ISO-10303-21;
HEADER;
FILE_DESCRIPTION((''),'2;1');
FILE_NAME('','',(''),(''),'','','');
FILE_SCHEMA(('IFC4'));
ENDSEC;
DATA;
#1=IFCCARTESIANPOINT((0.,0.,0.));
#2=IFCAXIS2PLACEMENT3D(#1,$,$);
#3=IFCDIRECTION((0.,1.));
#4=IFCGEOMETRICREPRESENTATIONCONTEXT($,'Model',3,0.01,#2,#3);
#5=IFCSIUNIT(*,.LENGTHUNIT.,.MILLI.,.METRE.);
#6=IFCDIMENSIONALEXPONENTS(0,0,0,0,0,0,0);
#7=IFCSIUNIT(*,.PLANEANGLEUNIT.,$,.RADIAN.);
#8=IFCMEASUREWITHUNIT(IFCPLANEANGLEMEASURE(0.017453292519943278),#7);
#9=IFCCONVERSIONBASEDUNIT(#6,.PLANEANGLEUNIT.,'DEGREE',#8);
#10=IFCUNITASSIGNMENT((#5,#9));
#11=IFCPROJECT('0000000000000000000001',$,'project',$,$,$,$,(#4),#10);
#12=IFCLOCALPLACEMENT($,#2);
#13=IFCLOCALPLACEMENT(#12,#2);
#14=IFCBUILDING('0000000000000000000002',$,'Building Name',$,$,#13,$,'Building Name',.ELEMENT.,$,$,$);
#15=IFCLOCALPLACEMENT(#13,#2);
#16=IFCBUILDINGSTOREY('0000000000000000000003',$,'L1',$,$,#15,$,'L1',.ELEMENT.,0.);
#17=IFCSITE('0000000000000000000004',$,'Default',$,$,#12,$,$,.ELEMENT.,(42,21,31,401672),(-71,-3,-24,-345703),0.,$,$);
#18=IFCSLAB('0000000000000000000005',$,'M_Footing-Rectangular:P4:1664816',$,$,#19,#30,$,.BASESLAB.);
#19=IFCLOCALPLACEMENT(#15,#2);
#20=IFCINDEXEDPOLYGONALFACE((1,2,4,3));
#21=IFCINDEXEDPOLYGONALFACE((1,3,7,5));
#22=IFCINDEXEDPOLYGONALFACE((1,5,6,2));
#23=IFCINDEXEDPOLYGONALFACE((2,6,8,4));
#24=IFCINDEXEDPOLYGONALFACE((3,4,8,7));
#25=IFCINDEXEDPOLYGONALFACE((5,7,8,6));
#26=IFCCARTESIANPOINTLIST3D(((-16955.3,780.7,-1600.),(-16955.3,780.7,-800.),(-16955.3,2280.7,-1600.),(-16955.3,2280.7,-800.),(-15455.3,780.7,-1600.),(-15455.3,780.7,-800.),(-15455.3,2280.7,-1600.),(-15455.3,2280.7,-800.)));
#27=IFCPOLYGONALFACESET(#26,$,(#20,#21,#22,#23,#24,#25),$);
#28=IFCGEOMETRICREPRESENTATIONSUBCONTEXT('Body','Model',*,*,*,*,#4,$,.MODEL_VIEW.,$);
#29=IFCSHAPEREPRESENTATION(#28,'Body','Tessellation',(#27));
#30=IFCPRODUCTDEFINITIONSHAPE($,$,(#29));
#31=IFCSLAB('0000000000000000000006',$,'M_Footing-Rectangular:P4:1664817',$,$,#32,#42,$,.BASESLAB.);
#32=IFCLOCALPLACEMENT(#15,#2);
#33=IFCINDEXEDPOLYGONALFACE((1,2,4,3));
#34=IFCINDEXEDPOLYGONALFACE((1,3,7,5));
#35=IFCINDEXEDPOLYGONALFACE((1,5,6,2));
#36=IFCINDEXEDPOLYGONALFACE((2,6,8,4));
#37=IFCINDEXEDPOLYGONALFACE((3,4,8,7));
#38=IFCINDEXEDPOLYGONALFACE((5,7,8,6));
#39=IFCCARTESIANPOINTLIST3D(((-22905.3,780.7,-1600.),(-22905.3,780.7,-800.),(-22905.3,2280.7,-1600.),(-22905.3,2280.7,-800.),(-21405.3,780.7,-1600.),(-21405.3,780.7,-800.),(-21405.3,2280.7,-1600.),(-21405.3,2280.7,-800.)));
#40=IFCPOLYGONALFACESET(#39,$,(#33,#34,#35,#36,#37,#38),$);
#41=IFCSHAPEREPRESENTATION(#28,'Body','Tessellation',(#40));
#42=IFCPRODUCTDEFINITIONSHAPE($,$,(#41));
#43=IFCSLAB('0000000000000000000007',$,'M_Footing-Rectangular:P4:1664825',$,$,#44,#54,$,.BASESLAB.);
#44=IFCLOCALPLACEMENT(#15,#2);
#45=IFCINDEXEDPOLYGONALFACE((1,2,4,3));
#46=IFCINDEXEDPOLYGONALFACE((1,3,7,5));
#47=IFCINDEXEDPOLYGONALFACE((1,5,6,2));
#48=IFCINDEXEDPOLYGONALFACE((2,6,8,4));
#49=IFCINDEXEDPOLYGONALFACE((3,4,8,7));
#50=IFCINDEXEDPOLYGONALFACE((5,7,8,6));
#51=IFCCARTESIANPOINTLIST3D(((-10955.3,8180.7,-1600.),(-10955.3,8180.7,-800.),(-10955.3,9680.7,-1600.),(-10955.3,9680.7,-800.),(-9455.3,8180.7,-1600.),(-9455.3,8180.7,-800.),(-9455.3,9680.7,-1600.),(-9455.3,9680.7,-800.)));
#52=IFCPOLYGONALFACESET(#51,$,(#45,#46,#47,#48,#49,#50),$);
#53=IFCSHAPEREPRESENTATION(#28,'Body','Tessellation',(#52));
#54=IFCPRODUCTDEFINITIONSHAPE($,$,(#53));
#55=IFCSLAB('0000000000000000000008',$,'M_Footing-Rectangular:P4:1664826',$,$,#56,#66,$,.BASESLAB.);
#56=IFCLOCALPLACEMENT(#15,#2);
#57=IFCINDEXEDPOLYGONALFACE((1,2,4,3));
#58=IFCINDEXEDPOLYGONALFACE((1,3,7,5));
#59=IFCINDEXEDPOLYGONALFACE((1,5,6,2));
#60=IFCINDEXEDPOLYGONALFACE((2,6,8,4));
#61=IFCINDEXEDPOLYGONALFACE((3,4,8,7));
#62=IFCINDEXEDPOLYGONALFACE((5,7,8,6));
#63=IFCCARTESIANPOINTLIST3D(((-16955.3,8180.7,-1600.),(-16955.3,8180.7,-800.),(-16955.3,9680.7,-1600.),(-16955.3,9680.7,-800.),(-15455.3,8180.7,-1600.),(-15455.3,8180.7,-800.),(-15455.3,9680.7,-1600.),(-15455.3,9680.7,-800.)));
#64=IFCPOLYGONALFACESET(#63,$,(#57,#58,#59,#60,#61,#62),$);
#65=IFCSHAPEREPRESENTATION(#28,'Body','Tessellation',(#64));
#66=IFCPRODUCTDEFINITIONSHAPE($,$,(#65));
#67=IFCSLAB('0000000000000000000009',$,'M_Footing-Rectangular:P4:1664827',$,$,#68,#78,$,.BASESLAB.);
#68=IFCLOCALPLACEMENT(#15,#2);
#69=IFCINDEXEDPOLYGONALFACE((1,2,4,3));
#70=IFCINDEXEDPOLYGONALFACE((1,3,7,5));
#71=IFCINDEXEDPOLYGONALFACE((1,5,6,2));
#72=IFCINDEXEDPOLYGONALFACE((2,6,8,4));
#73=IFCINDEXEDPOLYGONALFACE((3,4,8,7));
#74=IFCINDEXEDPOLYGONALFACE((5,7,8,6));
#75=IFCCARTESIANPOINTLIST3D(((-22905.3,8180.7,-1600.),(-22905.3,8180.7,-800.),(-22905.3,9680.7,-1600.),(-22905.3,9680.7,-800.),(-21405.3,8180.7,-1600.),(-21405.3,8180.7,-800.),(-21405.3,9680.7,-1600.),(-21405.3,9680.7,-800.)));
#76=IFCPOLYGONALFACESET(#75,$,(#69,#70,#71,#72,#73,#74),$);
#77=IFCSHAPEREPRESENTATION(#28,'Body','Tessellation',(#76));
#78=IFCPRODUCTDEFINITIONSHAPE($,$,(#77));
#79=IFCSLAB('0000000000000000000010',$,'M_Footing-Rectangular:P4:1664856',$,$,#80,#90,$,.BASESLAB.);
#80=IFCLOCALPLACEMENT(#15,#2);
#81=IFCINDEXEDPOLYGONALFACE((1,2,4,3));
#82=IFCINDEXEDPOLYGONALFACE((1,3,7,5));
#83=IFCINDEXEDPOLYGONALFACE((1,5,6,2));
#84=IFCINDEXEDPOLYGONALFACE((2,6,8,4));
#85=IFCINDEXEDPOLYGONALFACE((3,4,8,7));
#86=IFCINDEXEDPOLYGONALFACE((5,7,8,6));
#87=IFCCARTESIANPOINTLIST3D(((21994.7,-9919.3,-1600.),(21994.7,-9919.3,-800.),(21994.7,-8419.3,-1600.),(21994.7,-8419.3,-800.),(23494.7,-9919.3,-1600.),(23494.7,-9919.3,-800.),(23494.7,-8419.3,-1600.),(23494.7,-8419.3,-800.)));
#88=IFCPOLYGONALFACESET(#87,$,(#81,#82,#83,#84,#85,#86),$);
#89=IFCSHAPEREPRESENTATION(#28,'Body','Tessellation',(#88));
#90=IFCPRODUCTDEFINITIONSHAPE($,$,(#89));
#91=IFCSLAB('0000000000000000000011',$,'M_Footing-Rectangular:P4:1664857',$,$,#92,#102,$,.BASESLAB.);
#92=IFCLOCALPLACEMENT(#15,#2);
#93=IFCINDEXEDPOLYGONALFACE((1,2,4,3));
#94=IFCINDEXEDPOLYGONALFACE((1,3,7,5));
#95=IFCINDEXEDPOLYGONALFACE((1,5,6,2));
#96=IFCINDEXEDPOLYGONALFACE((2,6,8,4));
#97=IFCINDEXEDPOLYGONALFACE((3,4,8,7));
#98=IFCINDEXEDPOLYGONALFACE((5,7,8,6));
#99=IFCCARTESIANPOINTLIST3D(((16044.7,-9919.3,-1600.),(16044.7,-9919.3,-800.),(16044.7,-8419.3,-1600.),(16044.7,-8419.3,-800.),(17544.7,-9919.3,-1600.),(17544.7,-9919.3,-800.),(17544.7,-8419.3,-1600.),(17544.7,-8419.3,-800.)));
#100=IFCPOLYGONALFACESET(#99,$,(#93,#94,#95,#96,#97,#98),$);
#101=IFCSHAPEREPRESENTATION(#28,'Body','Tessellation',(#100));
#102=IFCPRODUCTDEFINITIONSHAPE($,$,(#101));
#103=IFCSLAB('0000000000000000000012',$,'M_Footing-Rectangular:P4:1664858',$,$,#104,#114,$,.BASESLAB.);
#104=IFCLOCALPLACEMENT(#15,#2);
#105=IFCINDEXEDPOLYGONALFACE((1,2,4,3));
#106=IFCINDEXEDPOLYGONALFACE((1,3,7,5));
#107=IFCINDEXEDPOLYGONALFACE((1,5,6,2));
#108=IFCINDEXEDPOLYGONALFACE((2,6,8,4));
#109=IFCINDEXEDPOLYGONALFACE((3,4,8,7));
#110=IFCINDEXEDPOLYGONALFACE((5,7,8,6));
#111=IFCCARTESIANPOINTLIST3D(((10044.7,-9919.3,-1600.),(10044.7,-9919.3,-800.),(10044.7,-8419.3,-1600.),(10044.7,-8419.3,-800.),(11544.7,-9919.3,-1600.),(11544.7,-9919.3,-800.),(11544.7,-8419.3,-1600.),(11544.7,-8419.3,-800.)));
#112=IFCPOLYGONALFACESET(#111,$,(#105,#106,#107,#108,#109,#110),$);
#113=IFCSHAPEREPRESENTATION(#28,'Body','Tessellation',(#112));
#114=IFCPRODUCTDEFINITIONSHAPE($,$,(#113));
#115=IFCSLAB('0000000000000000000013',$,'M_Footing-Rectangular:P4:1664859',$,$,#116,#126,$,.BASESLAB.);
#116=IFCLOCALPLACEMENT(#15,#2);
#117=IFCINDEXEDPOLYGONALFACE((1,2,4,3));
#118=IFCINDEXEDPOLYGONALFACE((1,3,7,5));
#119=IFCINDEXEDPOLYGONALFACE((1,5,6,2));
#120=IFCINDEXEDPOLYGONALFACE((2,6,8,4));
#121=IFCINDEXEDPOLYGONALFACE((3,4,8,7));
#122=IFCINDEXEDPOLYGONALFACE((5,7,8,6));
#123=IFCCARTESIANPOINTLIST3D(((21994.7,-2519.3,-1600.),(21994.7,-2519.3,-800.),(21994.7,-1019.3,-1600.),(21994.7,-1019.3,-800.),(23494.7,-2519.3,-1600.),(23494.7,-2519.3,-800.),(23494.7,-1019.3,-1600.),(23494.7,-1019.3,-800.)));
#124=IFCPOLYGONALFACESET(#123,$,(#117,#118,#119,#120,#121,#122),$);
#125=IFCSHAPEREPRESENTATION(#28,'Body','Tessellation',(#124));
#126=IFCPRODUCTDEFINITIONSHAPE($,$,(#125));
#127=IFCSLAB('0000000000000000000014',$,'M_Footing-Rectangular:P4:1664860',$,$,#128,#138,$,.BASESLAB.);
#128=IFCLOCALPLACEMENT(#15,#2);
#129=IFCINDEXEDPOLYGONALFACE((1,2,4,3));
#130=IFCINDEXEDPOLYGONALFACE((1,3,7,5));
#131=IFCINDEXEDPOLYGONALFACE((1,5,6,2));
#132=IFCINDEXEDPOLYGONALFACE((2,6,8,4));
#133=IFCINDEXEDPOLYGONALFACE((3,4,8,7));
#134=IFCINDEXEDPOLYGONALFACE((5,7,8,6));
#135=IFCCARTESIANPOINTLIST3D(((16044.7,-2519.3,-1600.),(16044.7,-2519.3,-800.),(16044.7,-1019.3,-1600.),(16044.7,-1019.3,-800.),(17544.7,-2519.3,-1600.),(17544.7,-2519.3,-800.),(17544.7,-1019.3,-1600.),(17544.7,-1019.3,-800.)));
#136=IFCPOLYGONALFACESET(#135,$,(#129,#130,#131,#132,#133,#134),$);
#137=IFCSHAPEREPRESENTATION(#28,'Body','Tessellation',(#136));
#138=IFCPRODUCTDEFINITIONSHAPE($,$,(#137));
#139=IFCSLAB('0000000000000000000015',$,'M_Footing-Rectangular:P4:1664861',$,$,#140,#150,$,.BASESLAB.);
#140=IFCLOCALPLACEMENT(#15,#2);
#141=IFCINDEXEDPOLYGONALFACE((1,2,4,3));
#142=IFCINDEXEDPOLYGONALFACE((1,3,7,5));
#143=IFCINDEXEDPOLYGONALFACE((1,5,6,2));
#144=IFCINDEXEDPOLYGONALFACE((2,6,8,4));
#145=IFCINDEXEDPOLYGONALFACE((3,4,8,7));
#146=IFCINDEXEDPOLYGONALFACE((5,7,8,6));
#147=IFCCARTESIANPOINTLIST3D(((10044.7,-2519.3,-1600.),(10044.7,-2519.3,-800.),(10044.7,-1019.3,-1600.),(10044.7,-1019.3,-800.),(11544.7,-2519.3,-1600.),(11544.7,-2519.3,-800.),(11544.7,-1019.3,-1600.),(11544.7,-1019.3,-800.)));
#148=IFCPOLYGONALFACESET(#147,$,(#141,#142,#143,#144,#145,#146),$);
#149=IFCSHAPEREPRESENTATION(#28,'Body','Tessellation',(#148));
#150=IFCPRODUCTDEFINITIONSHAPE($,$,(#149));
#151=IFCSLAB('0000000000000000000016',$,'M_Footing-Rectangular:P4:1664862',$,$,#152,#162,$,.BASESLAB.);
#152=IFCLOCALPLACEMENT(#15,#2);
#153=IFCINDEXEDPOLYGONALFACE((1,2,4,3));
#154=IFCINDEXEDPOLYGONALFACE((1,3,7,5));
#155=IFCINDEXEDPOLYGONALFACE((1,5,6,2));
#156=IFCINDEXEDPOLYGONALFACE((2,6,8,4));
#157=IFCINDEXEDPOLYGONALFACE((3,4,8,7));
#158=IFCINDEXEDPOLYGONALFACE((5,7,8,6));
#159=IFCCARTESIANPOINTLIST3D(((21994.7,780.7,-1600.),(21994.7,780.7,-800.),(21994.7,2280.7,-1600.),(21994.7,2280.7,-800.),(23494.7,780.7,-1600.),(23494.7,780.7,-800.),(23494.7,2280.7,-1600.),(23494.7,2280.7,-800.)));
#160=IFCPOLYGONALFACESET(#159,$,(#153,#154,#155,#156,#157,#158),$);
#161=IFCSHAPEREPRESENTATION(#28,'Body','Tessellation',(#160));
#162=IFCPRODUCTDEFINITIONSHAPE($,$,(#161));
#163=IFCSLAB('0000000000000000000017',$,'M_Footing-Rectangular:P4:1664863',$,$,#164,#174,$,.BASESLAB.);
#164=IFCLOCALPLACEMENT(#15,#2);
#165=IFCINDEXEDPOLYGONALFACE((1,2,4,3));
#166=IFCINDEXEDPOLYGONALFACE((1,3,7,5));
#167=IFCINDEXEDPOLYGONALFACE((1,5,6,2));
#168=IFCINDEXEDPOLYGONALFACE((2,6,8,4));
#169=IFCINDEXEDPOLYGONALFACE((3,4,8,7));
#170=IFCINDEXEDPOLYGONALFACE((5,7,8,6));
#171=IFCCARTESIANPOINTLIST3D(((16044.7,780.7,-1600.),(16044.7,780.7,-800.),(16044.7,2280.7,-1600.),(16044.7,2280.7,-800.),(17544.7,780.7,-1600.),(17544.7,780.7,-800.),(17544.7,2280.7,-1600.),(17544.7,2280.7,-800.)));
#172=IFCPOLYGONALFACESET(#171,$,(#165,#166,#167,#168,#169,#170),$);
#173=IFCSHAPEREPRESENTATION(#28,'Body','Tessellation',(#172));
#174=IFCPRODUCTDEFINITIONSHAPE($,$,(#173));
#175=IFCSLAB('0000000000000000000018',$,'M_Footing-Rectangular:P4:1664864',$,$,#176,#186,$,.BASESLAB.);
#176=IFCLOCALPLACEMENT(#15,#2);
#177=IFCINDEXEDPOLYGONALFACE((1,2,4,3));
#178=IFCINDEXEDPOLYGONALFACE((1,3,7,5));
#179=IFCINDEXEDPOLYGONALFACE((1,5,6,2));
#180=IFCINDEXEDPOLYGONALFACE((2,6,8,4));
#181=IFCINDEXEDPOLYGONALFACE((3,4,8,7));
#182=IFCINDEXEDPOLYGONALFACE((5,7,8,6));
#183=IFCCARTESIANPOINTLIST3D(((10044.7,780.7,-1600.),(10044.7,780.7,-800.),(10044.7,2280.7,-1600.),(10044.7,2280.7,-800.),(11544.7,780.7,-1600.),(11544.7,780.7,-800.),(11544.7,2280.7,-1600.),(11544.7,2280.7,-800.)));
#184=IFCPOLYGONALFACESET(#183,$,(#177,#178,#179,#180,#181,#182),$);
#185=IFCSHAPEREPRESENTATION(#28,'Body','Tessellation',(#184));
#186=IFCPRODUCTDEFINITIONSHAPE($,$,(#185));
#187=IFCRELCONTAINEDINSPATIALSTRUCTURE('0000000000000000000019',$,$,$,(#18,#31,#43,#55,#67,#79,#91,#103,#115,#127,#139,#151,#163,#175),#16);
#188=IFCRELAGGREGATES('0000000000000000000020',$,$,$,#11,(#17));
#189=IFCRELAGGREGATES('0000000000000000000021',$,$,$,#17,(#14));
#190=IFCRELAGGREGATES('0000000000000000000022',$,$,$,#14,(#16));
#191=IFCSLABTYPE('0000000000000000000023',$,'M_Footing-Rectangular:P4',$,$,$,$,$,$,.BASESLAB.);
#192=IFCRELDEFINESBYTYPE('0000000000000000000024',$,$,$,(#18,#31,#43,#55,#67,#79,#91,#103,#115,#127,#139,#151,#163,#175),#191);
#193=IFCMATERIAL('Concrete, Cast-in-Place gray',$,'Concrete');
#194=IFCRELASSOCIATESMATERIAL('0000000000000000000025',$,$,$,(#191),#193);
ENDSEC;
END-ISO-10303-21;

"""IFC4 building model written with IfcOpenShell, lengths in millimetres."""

from ifc_helpers import new_model, entity, si_unit, converted_unit, direction, frame, origin, place, context, subcontext, project, spatial, indexed_curve, outline, extrude, material, type_object, element, save


model = new_model("IFC4")

# Units and contexts
model_context = context("Model", 3, precision=0.01, world=origin(), true_north=direction((0.0, 1.0)))
body_context = subcontext(model_context, "Body", "Model", "MODEL_VIEW")
ifc_project = project(units=[si_unit("LENGTHUNIT", "METRE", prefix="MILLI"), converted_unit("PLANEANGLEUNIT", "DEGREE", entity("IfcPlaneAngleMeasure", 0.017453292519943278), si_unit("PLANEANGLEUNIT", "RADIAN"), dimensions=[0, 0, 0, 0, 0, 0, 0])], contexts=[model_context])

# Site, building, storey
site_placement = place(None, origin())
site = spatial("IfcSite", under=ifc_project, at=site_placement, Name="Default", CompositionType="ELEMENT", RefLatitude=(42, 21, 31, 401672), RefLongitude=(-71, -3, -24, -345703), RefElevation=0.0)
building_placement = place(site_placement, origin())
building = spatial("IfcBuilding", under=site, at=building_placement, Name="Building Name", LongName="Building Name", CompositionType="ELEMENT")
storey_placement = place(building_placement, origin())
storey = spatial("IfcBuildingStorey", under=building, at=storey_placement, Name="L1", LongName="L1", CompositionType="ELEMENT", Elevation=0.0)

# Slabs
ifc_material = material(Name="Concrete, Cast-in-Place gray", Category="Concrete")
slab_type = type_object("IfcSlabType", Name="M_Footing-Rectangular:P4", PredefinedType="BASESLAB", material=ifc_material)
slab_1_placement = place(storey_placement, origin())
element("IfcSlab", 1, at=slab_1_placement, inside=storey, type_object=slab_type, Name="M_Footing-Rectangular:P4:1664816", PredefinedType="BASESLAB", context=body_context, shape_type="SweptSolid", body=[
    extrude(outline(indexed_curve([(-750.0, -750.0), (750.0, -750.0), (750.0, 750.0), (-750.0, 750.0), (-750.0, -750.0)], self_intersect=False)), frame((-16205.3, 1530.7, -1600.0), z_axis=(0.0, 0.0, 1.0), x_axis=(-1.0, 0.0, 0.0)), (0.0, 0.0, 1.0), 800.0),
])
slab_2_placement = place(storey_placement, origin())
element("IfcSlab", 2, at=slab_2_placement, inside=storey, type_object=slab_type, Name="M_Footing-Rectangular:P4:1664817", PredefinedType="BASESLAB", context=body_context, shape_type="SweptSolid", body=[
    extrude(outline(indexed_curve([(-750.0, -750.0), (750.0, -750.0), (750.0, 750.0), (-750.0, 750.0), (-750.0, -750.0)], self_intersect=False)), frame((-22155.3, 1530.7, -1600.0), z_axis=(0.0, 0.0, 1.0), x_axis=(-1.0, 0.0, 0.0)), (0.0, 0.0, 1.0), 800.0),
])
slab_3_placement = place(storey_placement, origin())
element("IfcSlab", 3, at=slab_3_placement, inside=storey, type_object=slab_type, Name="M_Footing-Rectangular:P4:1664825", PredefinedType="BASESLAB", context=body_context, shape_type="SweptSolid", body=[
    extrude(outline(indexed_curve([(-750.0, -750.0), (750.0, -750.0), (750.0, 750.0), (-750.0, 750.0), (-750.0, -750.0)], self_intersect=False)), frame((-10205.3, 8930.7, -1600.0), z_axis=(0.0, 0.0, 1.0), x_axis=(-1.0, 0.0, 0.0)), (0.0, 0.0, 1.0), 800.0),
])
slab_4_placement = place(storey_placement, origin())
element("IfcSlab", 4, at=slab_4_placement, inside=storey, type_object=slab_type, Name="M_Footing-Rectangular:P4:1664826", PredefinedType="BASESLAB", context=body_context, shape_type="SweptSolid", body=[
    extrude(outline(indexed_curve([(-750.0, -750.0), (750.0, -750.0), (750.0, 750.0), (-750.0, 750.0), (-750.0, -750.0)], self_intersect=False)), frame((-16205.3, 8930.7, -1600.0), z_axis=(0.0, 0.0, 1.0), x_axis=(-1.0, 0.0, 0.0)), (0.0, 0.0, 1.0), 800.0),
])
slab_5_placement = place(storey_placement, origin())
element("IfcSlab", 5, at=slab_5_placement, inside=storey, type_object=slab_type, Name="M_Footing-Rectangular:P4:1664827", PredefinedType="BASESLAB", context=body_context, shape_type="SweptSolid", body=[
    extrude(outline(indexed_curve([(-750.0, -750.0), (750.0, -750.0), (750.0, 750.0), (-750.0, 750.0), (-750.0, -750.0)], self_intersect=False)), frame((-22155.3, 8930.7, -1600.0), z_axis=(0.0, 0.0, 1.0), x_axis=(-1.0, 0.0, 0.0)), (0.0, 0.0, 1.0), 800.0),
])
slab_6_placement = place(storey_placement, origin())
element("IfcSlab", 6, at=slab_6_placement, inside=storey, type_object=slab_type, Name="M_Footing-Rectangular:P4:1664856", PredefinedType="BASESLAB", context=body_context, shape_type="SweptSolid", body=[
    extrude(outline(indexed_curve([(-750.0, -750.0), (750.0, -750.0), (750.0, 750.0), (-750.0, 750.0), (-750.0, -750.0)], self_intersect=False)), frame((22744.7, -9169.3, -1600.0), z_axis=(0.0, 0.0, 1.0), x_axis=(-1.0, 0.0, 0.0)), (0.0, 0.0, 1.0), 800.0),
])
slab_7_placement = place(storey_placement, origin())
element("IfcSlab", 7, at=slab_7_placement, inside=storey, type_object=slab_type, Name="M_Footing-Rectangular:P4:1664857", PredefinedType="BASESLAB", context=body_context, shape_type="SweptSolid", body=[
    extrude(outline(indexed_curve([(-750.0, -750.0), (750.0, -750.0), (750.0, 750.0), (-750.0, 750.0), (-750.0, -750.0)], self_intersect=False)), frame((16794.7, -9169.3, -1600.0), z_axis=(0.0, 0.0, 1.0), x_axis=(-1.0, 0.0, 0.0)), (0.0, 0.0, 1.0), 800.0),
])
slab_8_placement = place(storey_placement, origin())
element("IfcSlab", 8, at=slab_8_placement, inside=storey, type_object=slab_type, Name="M_Footing-Rectangular:P4:1664858", PredefinedType="BASESLAB", context=body_context, shape_type="SweptSolid", body=[
    extrude(outline(indexed_curve([(-750.0, -750.0), (750.0, -750.0), (750.0, 750.0), (-750.0, 750.0), (-750.0, -750.0)], self_intersect=False)), frame((10794.7, -9169.3, -1600.0), z_axis=(0.0, 0.0, 1.0), x_axis=(-1.0, 0.0, 0.0)), (0.0, 0.0, 1.0), 800.0),
])
slab_9_placement = place(storey_placement, origin())
element("IfcSlab", 9, at=slab_9_placement, inside=storey, type_object=slab_type, Name="M_Footing-Rectangular:P4:1664859", PredefinedType="BASESLAB", context=body_context, shape_type="SweptSolid", body=[
    extrude(outline(indexed_curve([(-750.0, -750.0), (750.0, -750.0), (750.0, 750.0), (-750.0, 750.0), (-750.0, -750.0)], self_intersect=False)), frame((22744.7, -1769.3, -1600.0), z_axis=(0.0, 0.0, 1.0), x_axis=(-1.0, 0.0, 0.0)), (0.0, 0.0, 1.0), 800.0),
])
slab_10_placement = place(storey_placement, origin())
element("IfcSlab", 10, at=slab_10_placement, inside=storey, type_object=slab_type, Name="M_Footing-Rectangular:P4:1664860", PredefinedType="BASESLAB", context=body_context, shape_type="SweptSolid", body=[
    extrude(outline(indexed_curve([(-750.0, -750.0), (750.0, -750.0), (750.0, 750.0), (-750.0, 750.0), (-750.0, -750.0)], self_intersect=False)), frame((16794.7, -1769.3, -1600.0), z_axis=(0.0, 0.0, 1.0), x_axis=(-1.0, 0.0, 0.0)), (0.0, 0.0, 1.0), 800.0),
])
slab_11_placement = place(storey_placement, origin())
element("IfcSlab", 11, at=slab_11_placement, inside=storey, type_object=slab_type, Name="M_Footing-Rectangular:P4:1664861", PredefinedType="BASESLAB", context=body_context, shape_type="SweptSolid", body=[
    extrude(outline(indexed_curve([(-750.0, -750.0), (750.0, -750.0), (750.0, 750.0), (-750.0, 750.0), (-750.0, -750.0)], self_intersect=False)), frame((10794.7, -1769.3, -1600.0), z_axis=(0.0, 0.0, 1.0), x_axis=(-1.0, 0.0, 0.0)), (0.0, 0.0, 1.0), 800.0),
])
slab_12_placement = place(storey_placement, origin())
element("IfcSlab", 12, at=slab_12_placement, inside=storey, type_object=slab_type, Name="M_Footing-Rectangular:P4:1664862", PredefinedType="BASESLAB", context=body_context, shape_type="SweptSolid", body=[
    extrude(outline(indexed_curve([(-750.0, -750.0), (750.0, -750.0), (750.0, 750.0), (-750.0, 750.0), (-750.0, -750.0)], self_intersect=False)), frame((22744.7, 1530.7, -1600.0), z_axis=(0.0, 0.0, 1.0), x_axis=(-1.0, 0.0, 0.0)), (0.0, 0.0, 1.0), 800.0),
])
slab_13_placement = place(storey_placement, origin())
element("IfcSlab", 13, at=slab_13_placement, inside=storey, type_object=slab_type, Name="M_Footing-Rectangular:P4:1664863", PredefinedType="BASESLAB", context=body_context, shape_type="SweptSolid", body=[
    extrude(outline(indexed_curve([(-750.0, -750.0), (750.0, -750.0), (750.0, 750.0), (-750.0, 750.0), (-750.0, -750.0)], self_intersect=False)), frame((16794.7, 1530.7, -1600.0), z_axis=(0.0, 0.0, 1.0), x_axis=(-1.0, 0.0, 0.0)), (0.0, 0.0, 1.0), 800.0),
])
slab_14_placement = place(storey_placement, origin())
element("IfcSlab", 14, at=slab_14_placement, inside=storey, type_object=slab_type, Name="M_Footing-Rectangular:P4:1664864", PredefinedType="BASESLAB", context=body_context, shape_type="SweptSolid", body=[
    extrude(outline(indexed_curve([(-750.0, -750.0), (750.0, -750.0), (750.0, 750.0), (-750.0, 750.0), (-750.0, -750.0)], self_intersect=False)), frame((10794.7, 1530.7, -1600.0), z_axis=(0.0, 0.0, 1.0), x_axis=(-1.0, 0.0, 0.0)), (0.0, 0.0, 1.0), 800.0),
])

save(model, "model.ifc")
